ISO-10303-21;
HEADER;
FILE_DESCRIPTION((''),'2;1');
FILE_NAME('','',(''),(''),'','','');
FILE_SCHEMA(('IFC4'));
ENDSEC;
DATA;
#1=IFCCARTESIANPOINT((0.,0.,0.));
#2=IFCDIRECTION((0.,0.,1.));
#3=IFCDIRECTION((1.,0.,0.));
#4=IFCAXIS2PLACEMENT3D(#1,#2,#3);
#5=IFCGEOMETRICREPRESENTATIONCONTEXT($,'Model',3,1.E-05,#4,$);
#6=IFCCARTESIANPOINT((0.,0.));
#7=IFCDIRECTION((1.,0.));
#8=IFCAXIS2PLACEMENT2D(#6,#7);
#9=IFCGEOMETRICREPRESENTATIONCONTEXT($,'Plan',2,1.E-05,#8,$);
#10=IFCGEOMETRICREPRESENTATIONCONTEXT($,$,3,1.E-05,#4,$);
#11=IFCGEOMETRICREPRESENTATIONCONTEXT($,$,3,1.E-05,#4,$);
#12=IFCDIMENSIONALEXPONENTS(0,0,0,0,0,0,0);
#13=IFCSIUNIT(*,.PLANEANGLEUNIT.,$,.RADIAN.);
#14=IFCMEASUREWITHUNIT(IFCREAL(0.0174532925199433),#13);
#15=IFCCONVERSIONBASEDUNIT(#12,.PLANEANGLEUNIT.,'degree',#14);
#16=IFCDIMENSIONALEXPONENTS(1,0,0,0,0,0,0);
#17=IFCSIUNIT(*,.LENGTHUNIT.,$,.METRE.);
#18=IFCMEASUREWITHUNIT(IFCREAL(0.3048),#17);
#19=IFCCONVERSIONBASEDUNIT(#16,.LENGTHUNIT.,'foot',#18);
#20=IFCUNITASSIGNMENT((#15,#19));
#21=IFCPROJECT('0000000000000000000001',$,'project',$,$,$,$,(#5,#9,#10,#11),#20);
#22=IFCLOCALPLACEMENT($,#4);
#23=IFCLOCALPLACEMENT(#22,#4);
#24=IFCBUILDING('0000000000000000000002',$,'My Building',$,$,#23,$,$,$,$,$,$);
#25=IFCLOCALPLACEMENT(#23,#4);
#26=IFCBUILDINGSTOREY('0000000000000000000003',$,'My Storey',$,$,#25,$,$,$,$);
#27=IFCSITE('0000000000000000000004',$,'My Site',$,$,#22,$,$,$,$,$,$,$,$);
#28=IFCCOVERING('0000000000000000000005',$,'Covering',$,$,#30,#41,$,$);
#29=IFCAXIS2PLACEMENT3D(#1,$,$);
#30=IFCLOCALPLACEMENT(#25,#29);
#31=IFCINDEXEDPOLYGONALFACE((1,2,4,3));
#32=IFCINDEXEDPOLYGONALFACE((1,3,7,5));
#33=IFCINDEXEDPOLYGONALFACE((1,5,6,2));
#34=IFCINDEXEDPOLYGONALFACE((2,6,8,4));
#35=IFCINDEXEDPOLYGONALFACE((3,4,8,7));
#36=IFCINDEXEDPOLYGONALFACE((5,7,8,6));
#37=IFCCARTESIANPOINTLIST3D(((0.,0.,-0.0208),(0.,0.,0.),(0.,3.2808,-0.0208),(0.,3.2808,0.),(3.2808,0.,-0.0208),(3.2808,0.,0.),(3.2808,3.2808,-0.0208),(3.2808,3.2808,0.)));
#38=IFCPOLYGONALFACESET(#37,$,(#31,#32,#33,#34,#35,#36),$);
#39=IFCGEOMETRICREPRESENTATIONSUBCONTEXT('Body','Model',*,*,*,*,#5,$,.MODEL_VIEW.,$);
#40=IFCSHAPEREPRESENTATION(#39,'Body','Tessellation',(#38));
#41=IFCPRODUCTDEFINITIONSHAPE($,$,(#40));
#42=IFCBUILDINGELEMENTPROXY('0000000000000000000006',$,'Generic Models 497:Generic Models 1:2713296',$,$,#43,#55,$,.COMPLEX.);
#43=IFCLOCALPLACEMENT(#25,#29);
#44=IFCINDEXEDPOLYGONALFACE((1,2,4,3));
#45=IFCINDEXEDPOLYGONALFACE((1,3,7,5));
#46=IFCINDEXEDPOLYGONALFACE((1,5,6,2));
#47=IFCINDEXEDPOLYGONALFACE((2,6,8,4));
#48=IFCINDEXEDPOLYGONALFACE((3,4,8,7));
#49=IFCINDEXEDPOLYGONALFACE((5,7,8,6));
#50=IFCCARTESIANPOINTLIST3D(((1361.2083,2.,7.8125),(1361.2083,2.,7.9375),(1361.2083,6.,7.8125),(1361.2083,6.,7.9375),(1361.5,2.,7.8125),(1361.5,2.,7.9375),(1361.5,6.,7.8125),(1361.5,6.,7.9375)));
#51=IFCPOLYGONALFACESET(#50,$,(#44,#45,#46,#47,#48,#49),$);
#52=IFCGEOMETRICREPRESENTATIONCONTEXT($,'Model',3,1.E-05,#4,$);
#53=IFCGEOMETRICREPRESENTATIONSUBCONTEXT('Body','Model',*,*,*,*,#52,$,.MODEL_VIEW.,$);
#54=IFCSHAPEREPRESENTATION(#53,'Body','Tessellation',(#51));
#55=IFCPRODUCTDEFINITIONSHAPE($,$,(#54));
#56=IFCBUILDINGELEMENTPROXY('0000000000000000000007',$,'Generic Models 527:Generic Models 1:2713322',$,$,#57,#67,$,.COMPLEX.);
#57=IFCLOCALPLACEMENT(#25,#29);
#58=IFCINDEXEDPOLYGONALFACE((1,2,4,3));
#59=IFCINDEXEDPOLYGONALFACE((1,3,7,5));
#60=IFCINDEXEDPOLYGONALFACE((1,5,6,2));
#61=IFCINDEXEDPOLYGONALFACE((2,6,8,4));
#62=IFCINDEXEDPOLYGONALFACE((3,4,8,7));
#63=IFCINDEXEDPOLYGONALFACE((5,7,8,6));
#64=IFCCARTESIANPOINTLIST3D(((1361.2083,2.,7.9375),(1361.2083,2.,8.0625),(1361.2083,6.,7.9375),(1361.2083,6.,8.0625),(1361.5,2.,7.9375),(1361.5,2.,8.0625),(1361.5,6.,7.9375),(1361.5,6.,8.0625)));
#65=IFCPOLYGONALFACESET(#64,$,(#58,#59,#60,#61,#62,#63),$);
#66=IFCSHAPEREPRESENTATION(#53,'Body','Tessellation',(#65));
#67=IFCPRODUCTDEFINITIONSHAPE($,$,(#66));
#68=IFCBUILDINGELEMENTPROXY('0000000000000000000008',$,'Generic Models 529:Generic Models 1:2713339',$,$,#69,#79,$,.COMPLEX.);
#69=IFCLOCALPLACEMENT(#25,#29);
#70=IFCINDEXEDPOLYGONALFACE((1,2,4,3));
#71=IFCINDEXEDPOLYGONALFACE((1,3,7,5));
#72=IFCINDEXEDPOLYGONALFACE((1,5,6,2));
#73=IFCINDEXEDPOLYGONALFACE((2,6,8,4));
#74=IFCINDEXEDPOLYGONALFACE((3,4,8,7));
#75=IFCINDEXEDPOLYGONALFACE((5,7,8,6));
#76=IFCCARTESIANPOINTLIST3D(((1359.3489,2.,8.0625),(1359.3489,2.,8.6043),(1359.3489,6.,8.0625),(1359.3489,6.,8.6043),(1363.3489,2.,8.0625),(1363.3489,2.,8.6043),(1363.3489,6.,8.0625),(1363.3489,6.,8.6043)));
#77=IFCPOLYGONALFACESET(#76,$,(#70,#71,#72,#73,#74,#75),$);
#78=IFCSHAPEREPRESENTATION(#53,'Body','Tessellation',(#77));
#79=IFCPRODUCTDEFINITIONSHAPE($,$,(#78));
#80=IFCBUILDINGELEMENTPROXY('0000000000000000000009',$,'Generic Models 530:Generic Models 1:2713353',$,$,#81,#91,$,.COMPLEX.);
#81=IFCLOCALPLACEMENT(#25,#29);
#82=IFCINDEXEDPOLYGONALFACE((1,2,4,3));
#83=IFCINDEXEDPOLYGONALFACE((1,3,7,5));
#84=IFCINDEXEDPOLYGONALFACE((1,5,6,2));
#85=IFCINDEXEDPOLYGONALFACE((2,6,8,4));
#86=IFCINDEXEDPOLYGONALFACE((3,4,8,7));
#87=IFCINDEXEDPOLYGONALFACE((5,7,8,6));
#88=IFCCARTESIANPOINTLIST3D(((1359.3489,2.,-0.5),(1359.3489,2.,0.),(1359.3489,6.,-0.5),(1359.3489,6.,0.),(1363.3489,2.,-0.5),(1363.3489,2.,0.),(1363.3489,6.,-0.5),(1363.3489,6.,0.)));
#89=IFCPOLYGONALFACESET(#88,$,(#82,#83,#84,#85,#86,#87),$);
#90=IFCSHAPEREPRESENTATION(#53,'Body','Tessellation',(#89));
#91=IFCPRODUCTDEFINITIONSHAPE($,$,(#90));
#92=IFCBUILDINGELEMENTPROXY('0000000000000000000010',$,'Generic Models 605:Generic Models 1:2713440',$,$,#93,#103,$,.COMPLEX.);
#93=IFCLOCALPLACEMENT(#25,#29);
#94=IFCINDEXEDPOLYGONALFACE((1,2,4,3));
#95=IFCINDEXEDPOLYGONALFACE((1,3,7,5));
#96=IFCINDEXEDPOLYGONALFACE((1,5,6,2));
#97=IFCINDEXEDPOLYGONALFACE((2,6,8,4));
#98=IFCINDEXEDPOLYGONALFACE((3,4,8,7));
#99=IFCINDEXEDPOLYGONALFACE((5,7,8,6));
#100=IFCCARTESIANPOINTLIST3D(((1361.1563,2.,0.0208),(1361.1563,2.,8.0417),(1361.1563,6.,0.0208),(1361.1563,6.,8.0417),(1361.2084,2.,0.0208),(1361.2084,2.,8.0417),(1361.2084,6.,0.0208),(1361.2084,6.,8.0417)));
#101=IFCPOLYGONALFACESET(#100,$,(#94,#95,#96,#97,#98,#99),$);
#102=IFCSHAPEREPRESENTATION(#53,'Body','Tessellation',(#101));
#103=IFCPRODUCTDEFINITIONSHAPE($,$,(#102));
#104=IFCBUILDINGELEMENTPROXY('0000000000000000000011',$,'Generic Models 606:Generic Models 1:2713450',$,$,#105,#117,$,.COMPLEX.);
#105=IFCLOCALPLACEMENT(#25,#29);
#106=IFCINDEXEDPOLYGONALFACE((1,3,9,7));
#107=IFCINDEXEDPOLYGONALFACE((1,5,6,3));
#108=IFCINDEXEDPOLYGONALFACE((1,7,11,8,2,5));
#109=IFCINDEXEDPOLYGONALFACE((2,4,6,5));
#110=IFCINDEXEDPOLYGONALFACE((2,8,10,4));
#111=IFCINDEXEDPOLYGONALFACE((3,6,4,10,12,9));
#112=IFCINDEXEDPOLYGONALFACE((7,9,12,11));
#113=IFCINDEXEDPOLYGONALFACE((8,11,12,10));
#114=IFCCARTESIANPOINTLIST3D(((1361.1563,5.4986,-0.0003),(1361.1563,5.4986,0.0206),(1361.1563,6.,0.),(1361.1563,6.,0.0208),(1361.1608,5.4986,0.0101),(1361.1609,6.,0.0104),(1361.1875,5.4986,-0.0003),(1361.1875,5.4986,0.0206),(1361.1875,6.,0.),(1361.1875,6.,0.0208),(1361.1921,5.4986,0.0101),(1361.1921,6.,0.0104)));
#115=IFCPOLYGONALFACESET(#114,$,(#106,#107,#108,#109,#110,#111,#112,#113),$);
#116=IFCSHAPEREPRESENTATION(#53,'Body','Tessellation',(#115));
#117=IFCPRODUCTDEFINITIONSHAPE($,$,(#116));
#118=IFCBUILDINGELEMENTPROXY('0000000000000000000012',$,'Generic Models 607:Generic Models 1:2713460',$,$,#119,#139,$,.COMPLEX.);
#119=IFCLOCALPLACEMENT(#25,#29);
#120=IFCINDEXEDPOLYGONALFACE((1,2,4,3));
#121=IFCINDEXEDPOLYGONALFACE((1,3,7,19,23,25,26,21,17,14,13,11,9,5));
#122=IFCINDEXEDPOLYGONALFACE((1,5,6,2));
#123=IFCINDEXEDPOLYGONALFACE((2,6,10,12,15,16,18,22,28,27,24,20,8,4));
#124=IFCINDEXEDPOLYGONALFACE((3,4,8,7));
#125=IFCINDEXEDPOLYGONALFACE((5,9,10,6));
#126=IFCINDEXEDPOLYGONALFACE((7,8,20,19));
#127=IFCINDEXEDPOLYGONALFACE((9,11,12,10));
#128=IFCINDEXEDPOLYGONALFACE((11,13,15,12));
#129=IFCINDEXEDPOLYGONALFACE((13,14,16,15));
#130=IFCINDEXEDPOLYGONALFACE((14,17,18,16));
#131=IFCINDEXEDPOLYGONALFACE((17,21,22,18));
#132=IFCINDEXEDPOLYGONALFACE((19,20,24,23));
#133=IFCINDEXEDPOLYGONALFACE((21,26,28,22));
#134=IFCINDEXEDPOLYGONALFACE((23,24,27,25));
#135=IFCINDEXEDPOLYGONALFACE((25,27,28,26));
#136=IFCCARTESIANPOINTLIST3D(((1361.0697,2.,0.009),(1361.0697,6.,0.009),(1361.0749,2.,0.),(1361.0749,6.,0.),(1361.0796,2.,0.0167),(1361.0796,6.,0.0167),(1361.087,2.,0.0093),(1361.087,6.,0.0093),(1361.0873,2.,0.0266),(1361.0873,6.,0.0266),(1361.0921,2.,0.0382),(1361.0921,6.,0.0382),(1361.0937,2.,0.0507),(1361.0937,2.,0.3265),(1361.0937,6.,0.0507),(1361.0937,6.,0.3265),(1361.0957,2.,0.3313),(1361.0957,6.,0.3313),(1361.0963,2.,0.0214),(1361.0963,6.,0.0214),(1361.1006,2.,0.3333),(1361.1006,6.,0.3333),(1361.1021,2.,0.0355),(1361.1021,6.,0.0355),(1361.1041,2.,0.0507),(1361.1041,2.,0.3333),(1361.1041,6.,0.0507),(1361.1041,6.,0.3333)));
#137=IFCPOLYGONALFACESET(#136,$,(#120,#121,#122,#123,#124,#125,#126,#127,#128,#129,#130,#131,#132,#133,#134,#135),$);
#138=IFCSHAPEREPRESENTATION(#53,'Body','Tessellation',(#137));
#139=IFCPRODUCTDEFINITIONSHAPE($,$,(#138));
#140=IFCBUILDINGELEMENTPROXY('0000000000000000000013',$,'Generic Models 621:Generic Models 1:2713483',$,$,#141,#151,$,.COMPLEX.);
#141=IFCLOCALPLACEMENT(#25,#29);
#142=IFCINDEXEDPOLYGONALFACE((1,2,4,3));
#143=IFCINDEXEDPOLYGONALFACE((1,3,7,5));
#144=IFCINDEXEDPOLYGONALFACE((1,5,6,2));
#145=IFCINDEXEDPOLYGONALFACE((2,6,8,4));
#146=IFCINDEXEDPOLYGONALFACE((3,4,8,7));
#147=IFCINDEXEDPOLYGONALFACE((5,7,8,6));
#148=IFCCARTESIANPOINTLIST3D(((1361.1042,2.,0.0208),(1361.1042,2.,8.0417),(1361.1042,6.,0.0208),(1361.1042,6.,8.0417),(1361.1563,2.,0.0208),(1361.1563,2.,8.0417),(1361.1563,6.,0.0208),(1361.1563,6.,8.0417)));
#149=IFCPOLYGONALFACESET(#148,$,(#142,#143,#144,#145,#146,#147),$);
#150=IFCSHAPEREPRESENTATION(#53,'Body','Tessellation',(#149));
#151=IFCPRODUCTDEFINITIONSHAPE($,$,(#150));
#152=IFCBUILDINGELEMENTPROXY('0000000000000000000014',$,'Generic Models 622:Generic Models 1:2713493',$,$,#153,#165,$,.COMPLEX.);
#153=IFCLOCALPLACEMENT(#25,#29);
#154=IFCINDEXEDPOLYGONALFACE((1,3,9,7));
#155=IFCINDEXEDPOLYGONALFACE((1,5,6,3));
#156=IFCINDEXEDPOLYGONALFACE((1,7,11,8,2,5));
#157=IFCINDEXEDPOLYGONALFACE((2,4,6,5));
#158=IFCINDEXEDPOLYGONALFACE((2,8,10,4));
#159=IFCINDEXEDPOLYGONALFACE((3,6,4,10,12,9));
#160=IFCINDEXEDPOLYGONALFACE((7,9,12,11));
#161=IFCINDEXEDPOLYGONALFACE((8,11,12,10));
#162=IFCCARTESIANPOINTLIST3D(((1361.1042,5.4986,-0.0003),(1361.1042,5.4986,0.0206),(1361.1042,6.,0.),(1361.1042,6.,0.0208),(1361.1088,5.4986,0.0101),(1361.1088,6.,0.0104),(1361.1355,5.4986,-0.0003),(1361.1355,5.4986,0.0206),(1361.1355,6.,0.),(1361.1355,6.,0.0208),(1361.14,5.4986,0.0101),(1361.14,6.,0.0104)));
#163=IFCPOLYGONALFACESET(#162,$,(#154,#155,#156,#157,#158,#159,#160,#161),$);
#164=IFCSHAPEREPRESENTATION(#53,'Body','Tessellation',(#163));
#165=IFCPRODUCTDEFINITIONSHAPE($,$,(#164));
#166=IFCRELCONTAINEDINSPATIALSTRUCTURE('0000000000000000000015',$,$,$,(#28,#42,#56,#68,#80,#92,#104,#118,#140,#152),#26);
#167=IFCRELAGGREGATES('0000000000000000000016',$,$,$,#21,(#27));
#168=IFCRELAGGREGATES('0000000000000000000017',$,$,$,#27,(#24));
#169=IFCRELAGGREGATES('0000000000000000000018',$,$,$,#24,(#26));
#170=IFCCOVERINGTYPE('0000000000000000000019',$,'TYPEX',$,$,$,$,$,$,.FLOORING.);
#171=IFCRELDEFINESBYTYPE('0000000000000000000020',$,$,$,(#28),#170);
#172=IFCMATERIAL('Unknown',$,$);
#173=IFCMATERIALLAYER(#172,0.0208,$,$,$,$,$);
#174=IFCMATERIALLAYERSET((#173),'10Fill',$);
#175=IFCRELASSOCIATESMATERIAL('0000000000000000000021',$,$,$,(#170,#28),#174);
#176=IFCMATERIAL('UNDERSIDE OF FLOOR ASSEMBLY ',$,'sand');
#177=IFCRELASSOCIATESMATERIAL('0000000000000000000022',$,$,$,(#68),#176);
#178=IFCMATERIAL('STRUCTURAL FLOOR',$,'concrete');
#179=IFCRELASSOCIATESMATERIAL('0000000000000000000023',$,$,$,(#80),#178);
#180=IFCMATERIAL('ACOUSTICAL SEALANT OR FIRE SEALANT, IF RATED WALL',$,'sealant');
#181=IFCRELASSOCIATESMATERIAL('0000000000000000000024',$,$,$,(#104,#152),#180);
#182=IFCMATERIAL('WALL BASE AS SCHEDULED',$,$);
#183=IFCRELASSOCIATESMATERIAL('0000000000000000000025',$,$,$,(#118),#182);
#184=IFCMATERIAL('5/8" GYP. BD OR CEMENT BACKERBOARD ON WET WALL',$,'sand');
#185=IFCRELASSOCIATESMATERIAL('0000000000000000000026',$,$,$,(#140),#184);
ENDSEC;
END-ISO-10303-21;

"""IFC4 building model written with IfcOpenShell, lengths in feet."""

from ifc_helpers import new_model, entity, si_unit, converted_unit, frame, origin_with_axes, origin_2d_with_axis, place, context, subcontext, project, spatial, polyline, indexed_curve, outline, extrude, material, layer, layer_set, layer_usage, type_object, element, save


model = new_model("IFC4")

# Units and contexts
model_context_1 = context("Model", 3, precision=1e-05, world=origin_with_axes())
plan_context = context("Plan", 2, precision=1e-05, world=origin_2d_with_axis())
model_context_2 = context("Model", 3, precision=1e-05, world=origin_with_axes())
context_of_model_1 = context(None, 3, precision=1e-05, world=origin_with_axes())
context_of_model_2 = context(None, 3, precision=1e-05, world=origin_with_axes())
body_context_1 = subcontext(model_context_1, "Body", "Model", "MODEL_VIEW")
body_context_2 = subcontext(model_context_2, "Body", "Model", "MODEL_VIEW")
ifc_project = project(units=[converted_unit("PLANEANGLEUNIT", "degree", entity("IfcReal", 0.0174532925199433), si_unit("PLANEANGLEUNIT", "RADIAN"), dimensions=[0, 0, 0, 0, 0, 0, 0]), converted_unit("LENGTHUNIT", "foot", entity("IfcReal", 0.3048), si_unit("LENGTHUNIT", "METRE"), dimensions=[1, 0, 0, 0, 0, 0, 0])], contexts=[model_context_1, plan_context, context_of_model_1, context_of_model_2])

# Site, building, storey
site_placement = place(None, origin_with_axes())
site = spatial("IfcSite", under=ifc_project, at=site_placement, Name="My Site")
building_placement = place(site_placement, origin_with_axes())
building = spatial("IfcBuilding", under=site, at=building_placement, Name="My Building")
storey_placement = place(building_placement, origin_with_axes())
storey = spatial("IfcBuildingStorey", under=building, at=storey_placement, Name="My Storey")

# Covering
ifc_material_1 = material(Name="Unknown")
ifc_layer_1 = layer(ifc_material_1, 0.0208)
ifc_layer_set_1 = layer_set([ifc_layer_1], Name="10Fill")
ifc_layer_usage_1 = layer_usage(ifc_layer_set_1, "AXIS3", "POSITIVE", 0.0)
covering_type = type_object("IfcCoveringType", Name="TYPEX", PredefinedType="FLOORING", material=ifc_layer_set_1)
covering_placement = place(storey_placement, frame((0.0, 0.0, -0.0208), z_axis=(0.0, 0.0, 1.0), x_axis=(1.0, 0.0, 0.0)))
element("IfcCovering", 1, at=covering_placement, inside=storey, type_object=covering_type, material=ifc_layer_usage_1, Name="Covering", context=body_context_1, shape_type="SweptSolid", body=[
    extrude(outline(indexed_curve([(0.0, 0.0), (3.2808, 0.0), (3.2808, 3.2808), (0.0, 3.2808), (0.0, 0.0)])), None, (0.0, 0.0, 1.0), 0.0208),
])

# Building element proxies
for number, where, z_axis, x_axis, name in (
    (2, (1361.2083, 6.0, 7.8125), (0.0, -1.0, 0.0), (0.0, 0.0, 1.0), "Generic Models 497:Generic Models 1:2713296"),
    (3, (1361.2083, 6.0, 7.9375), (0.0, -1.0, 0.0), (0.0, 0.0, 1.0), "Generic Models 527:Generic Models 1:2713322"),
):
    element("IfcBuildingElementProxy", number, at=place(storey_placement, frame(where, z_axis=z_axis, x_axis=x_axis)), inside=storey, Name=name, PredefinedType="COMPLEX", context=body_context_2, shape_type="SweptSolid", body=[
        extrude(outline(polyline([(-0.1458, -0.0625), (0.1458, -0.0625), (0.1458, 0.0625), (-0.1458, 0.0625), (-0.1458, -0.0625)])), frame((0.0625, -0.1458, 0.0), z_axis=(0.0, 0.0, -1.0), x_axis=(0.0, 1.0, 0.0)), (0.0, 0.0, -1.0), 4.0),
    ])
ifc_material_2 = material(Name="UNDERSIDE OF FLOOR ASSEMBLY ", Category="sand")
proxy_1_placement = place(storey_placement, frame((1359.3489, 6.0, 8.0625), z_axis=(0.0, -1.0, 0.0), x_axis=(0.0, 0.0, 1.0)))
element("IfcBuildingElementProxy", 4, at=proxy_1_placement, inside=storey, material=ifc_material_2, Name="Generic Models 529:Generic Models 1:2713339", PredefinedType="COMPLEX", context=body_context_2, shape_type="SweptSolid", body=[
    extrude(outline(polyline([(-0.2709, -2.0), (0.2709, -2.0), (0.2709, 2.0), (-0.2709, 2.0), (-0.2709, -2.0)])), frame((0.2709, -2.0, 0.0), z_axis=(0.0, 0.0, -1.0), x_axis=(1.0, 0.0, 0.0)), (0.0, 0.0, -1.0), 4.0),
])
ifc_material_3 = material(Name="STRUCTURAL FLOOR", Category="concrete")
proxy_2_placement = place(storey_placement, frame((1359.3489, 6.0, -0.5), z_axis=(0.0, -1.0, 0.0), x_axis=(0.0, 0.0, 1.0)))
element("IfcBuildingElementProxy", 5, at=proxy_2_placement, inside=storey, material=ifc_material_3, Name="Generic Models 530:Generic Models 1:2713353", PredefinedType="COMPLEX", context=body_context_2, shape_type="SweptSolid", body=[
    extrude(outline(polyline([(-0.25, -2.0), (0.25, -2.0), (0.25, 2.0), (-0.25, 2.0), (-0.25, -2.0)])), frame((0.25, -2.0, 0.0), z_axis=(0.0, 0.0, -1.0), x_axis=(1.0, 0.0, 0.0)), (0.0, 0.0, -1.0), 4.0),
])
proxy_3_placement = place(storey_placement, frame((1361.1563, 6.0, 0.0208), z_axis=(0.0, -1.0, 0.0), x_axis=(0.0, 0.0, 1.0)))
element("IfcBuildingElementProxy", 6, at=proxy_3_placement, inside=storey, Name="Generic Models 605:Generic Models 1:2713440", PredefinedType="COMPLEX", context=body_context_2, shape_type="SweptSolid", body=[
    extrude(outline(polyline([(-0.026, -4.0104), (0.026, -4.0104), (0.026, 4.0104), (-0.026, 4.0104), (-0.026, -4.0104)])), frame((4.0104, -0.026, 0.0), z_axis=(0.0, 0.0, -1.0), x_axis=(0.0, 1.0, 0.0)), (0.0, 0.0, -1.0), 4.0),
])
ifc_material_4 = material(Name="ACOUSTICAL SEALANT OR FIRE SEALANT, IF RATED WALL", Category="sealant")
proxy_4_placement = place(storey_placement, frame((1361.1563, 6.0, 0.0), z_axis=(0.0, -1.0, 0.0), x_axis=(0.0, 0.0, 1.0)))
element("IfcBuildingElementProxy", 7, at=proxy_4_placement, inside=storey, material=ifc_material_4, Name="Generic Models 606:Generic Models 1:2713450", PredefinedType="COMPLEX", context=body_context_2, shape_type="SweptSolid", body=[
    extrude(outline(polyline([(0.0201, 0.0), (-0.0066, 0.0162), (-0.016, 0.0097), (-0.0175, -0.0016), (0.0093, -0.0178), (0.0107, -0.0065), (0.0201, 0.0)])), frame((0.0104, -0.0172, 0.0), z_axis=(0.0, 0.0, -1.0), x_axis=(0.51911, 0.854708, 0.0)), (-0.000285, -0.000479, -1.0), 0.5014),
])
ifc_material_5 = material(Name="WALL BASE AS SCHEDULED")
proxy_5_placement = place(storey_placement, frame((1361.0697, 6.0, 0.0), z_axis=(0.0, -1.0, 0.0), x_axis=(0.0, 0.0, 1.0)))
element("IfcBuildingElementProxy", 8, at=proxy_5_placement, inside=storey, material=ifc_material_5, Name="Generic Models 607:Generic Models 1:2713460", PredefinedType="COMPLEX", context=body_context_2, shape_type="SweptSolid", body=[
    extrude(outline(polyline([(0.2205, 0.0), (0.2206, 0.0036), (-0.0618, 0.0152), (-0.077, 0.0138), (-0.0914, 0.0086), (-0.1038, -0.0002), (-0.1136, -0.012), (-0.1048, -0.0175), (-0.0968, -0.0079), (-0.0865, -0.0007), (-0.0747, 0.0037), (-0.0622, 0.0048), (0.2133, -0.0066), (0.2183, -0.0048), (0.2205, 0.0)])), frame((0.113, -0.0218, 0.0), z_axis=(0.0, 0.0, -1.0), x_axis=(0.999153, -0.041137, 0.0)), (0.0, 0.0, -1.0), 4.0),
])
ifc_material_6 = material(Name="5/8\" GYP. BD OR CEMENT BACKERBOARD ON WET WALL", Category="sand")
proxy_6_placement = place(storey_placement, frame((1361.1042, 6.0, 0.0208), z_axis=(0.0, -1.0, 0.0), x_axis=(0.0, 0.0, 1.0)))
element("IfcBuildingElementProxy", 9, at=proxy_6_placement, inside=storey, material=ifc_material_6, Name="Generic Models 621:Generic Models 1:2713483", PredefinedType="COMPLEX", context=body_context_2, shape_type="SweptSolid", body=[
    extrude(outline(polyline([(-4.0104, -0.026), (4.0104, -0.026), (4.0104, 0.026), (-4.0104, 0.026), (-4.0104, -0.026)])), frame((4.0104, -0.026, 0.0), z_axis=(0.0, 0.0, -1.0), x_axis=(1.0, 0.0, 0.0)), (0.0, 0.0, -1.0), 4.0),
])
proxy_7_placement = place(storey_placement, frame((1361.1042, 6.0, 0.0), z_axis=(0.0, -1.0, 0.0), x_axis=(0.0, 0.0, 1.0)))
element("IfcBuildingElementProxy", 10, at=proxy_7_placement, inside=storey, material=ifc_material_4, Name="Generic Models 622:Generic Models 1:2713493", PredefinedType="COMPLEX", context=body_context_2, shape_type="SweptSolid", body=[
    extrude(outline(polyline([(0.0201, 0.0), (-0.0066, 0.0162), (-0.016, 0.0097), (-0.0175, -0.0016), (0.0093, -0.0178), (0.0107, -0.0065), (0.0201, 0.0)])), frame((0.0104, -0.0172, 0.0), z_axis=(0.0, 0.0, -1.0), x_axis=(0.51911, 0.854708, 0.0)), (-0.000285, -0.000479, -1.0), 0.5014),
])

save(model, "model.ifc")
